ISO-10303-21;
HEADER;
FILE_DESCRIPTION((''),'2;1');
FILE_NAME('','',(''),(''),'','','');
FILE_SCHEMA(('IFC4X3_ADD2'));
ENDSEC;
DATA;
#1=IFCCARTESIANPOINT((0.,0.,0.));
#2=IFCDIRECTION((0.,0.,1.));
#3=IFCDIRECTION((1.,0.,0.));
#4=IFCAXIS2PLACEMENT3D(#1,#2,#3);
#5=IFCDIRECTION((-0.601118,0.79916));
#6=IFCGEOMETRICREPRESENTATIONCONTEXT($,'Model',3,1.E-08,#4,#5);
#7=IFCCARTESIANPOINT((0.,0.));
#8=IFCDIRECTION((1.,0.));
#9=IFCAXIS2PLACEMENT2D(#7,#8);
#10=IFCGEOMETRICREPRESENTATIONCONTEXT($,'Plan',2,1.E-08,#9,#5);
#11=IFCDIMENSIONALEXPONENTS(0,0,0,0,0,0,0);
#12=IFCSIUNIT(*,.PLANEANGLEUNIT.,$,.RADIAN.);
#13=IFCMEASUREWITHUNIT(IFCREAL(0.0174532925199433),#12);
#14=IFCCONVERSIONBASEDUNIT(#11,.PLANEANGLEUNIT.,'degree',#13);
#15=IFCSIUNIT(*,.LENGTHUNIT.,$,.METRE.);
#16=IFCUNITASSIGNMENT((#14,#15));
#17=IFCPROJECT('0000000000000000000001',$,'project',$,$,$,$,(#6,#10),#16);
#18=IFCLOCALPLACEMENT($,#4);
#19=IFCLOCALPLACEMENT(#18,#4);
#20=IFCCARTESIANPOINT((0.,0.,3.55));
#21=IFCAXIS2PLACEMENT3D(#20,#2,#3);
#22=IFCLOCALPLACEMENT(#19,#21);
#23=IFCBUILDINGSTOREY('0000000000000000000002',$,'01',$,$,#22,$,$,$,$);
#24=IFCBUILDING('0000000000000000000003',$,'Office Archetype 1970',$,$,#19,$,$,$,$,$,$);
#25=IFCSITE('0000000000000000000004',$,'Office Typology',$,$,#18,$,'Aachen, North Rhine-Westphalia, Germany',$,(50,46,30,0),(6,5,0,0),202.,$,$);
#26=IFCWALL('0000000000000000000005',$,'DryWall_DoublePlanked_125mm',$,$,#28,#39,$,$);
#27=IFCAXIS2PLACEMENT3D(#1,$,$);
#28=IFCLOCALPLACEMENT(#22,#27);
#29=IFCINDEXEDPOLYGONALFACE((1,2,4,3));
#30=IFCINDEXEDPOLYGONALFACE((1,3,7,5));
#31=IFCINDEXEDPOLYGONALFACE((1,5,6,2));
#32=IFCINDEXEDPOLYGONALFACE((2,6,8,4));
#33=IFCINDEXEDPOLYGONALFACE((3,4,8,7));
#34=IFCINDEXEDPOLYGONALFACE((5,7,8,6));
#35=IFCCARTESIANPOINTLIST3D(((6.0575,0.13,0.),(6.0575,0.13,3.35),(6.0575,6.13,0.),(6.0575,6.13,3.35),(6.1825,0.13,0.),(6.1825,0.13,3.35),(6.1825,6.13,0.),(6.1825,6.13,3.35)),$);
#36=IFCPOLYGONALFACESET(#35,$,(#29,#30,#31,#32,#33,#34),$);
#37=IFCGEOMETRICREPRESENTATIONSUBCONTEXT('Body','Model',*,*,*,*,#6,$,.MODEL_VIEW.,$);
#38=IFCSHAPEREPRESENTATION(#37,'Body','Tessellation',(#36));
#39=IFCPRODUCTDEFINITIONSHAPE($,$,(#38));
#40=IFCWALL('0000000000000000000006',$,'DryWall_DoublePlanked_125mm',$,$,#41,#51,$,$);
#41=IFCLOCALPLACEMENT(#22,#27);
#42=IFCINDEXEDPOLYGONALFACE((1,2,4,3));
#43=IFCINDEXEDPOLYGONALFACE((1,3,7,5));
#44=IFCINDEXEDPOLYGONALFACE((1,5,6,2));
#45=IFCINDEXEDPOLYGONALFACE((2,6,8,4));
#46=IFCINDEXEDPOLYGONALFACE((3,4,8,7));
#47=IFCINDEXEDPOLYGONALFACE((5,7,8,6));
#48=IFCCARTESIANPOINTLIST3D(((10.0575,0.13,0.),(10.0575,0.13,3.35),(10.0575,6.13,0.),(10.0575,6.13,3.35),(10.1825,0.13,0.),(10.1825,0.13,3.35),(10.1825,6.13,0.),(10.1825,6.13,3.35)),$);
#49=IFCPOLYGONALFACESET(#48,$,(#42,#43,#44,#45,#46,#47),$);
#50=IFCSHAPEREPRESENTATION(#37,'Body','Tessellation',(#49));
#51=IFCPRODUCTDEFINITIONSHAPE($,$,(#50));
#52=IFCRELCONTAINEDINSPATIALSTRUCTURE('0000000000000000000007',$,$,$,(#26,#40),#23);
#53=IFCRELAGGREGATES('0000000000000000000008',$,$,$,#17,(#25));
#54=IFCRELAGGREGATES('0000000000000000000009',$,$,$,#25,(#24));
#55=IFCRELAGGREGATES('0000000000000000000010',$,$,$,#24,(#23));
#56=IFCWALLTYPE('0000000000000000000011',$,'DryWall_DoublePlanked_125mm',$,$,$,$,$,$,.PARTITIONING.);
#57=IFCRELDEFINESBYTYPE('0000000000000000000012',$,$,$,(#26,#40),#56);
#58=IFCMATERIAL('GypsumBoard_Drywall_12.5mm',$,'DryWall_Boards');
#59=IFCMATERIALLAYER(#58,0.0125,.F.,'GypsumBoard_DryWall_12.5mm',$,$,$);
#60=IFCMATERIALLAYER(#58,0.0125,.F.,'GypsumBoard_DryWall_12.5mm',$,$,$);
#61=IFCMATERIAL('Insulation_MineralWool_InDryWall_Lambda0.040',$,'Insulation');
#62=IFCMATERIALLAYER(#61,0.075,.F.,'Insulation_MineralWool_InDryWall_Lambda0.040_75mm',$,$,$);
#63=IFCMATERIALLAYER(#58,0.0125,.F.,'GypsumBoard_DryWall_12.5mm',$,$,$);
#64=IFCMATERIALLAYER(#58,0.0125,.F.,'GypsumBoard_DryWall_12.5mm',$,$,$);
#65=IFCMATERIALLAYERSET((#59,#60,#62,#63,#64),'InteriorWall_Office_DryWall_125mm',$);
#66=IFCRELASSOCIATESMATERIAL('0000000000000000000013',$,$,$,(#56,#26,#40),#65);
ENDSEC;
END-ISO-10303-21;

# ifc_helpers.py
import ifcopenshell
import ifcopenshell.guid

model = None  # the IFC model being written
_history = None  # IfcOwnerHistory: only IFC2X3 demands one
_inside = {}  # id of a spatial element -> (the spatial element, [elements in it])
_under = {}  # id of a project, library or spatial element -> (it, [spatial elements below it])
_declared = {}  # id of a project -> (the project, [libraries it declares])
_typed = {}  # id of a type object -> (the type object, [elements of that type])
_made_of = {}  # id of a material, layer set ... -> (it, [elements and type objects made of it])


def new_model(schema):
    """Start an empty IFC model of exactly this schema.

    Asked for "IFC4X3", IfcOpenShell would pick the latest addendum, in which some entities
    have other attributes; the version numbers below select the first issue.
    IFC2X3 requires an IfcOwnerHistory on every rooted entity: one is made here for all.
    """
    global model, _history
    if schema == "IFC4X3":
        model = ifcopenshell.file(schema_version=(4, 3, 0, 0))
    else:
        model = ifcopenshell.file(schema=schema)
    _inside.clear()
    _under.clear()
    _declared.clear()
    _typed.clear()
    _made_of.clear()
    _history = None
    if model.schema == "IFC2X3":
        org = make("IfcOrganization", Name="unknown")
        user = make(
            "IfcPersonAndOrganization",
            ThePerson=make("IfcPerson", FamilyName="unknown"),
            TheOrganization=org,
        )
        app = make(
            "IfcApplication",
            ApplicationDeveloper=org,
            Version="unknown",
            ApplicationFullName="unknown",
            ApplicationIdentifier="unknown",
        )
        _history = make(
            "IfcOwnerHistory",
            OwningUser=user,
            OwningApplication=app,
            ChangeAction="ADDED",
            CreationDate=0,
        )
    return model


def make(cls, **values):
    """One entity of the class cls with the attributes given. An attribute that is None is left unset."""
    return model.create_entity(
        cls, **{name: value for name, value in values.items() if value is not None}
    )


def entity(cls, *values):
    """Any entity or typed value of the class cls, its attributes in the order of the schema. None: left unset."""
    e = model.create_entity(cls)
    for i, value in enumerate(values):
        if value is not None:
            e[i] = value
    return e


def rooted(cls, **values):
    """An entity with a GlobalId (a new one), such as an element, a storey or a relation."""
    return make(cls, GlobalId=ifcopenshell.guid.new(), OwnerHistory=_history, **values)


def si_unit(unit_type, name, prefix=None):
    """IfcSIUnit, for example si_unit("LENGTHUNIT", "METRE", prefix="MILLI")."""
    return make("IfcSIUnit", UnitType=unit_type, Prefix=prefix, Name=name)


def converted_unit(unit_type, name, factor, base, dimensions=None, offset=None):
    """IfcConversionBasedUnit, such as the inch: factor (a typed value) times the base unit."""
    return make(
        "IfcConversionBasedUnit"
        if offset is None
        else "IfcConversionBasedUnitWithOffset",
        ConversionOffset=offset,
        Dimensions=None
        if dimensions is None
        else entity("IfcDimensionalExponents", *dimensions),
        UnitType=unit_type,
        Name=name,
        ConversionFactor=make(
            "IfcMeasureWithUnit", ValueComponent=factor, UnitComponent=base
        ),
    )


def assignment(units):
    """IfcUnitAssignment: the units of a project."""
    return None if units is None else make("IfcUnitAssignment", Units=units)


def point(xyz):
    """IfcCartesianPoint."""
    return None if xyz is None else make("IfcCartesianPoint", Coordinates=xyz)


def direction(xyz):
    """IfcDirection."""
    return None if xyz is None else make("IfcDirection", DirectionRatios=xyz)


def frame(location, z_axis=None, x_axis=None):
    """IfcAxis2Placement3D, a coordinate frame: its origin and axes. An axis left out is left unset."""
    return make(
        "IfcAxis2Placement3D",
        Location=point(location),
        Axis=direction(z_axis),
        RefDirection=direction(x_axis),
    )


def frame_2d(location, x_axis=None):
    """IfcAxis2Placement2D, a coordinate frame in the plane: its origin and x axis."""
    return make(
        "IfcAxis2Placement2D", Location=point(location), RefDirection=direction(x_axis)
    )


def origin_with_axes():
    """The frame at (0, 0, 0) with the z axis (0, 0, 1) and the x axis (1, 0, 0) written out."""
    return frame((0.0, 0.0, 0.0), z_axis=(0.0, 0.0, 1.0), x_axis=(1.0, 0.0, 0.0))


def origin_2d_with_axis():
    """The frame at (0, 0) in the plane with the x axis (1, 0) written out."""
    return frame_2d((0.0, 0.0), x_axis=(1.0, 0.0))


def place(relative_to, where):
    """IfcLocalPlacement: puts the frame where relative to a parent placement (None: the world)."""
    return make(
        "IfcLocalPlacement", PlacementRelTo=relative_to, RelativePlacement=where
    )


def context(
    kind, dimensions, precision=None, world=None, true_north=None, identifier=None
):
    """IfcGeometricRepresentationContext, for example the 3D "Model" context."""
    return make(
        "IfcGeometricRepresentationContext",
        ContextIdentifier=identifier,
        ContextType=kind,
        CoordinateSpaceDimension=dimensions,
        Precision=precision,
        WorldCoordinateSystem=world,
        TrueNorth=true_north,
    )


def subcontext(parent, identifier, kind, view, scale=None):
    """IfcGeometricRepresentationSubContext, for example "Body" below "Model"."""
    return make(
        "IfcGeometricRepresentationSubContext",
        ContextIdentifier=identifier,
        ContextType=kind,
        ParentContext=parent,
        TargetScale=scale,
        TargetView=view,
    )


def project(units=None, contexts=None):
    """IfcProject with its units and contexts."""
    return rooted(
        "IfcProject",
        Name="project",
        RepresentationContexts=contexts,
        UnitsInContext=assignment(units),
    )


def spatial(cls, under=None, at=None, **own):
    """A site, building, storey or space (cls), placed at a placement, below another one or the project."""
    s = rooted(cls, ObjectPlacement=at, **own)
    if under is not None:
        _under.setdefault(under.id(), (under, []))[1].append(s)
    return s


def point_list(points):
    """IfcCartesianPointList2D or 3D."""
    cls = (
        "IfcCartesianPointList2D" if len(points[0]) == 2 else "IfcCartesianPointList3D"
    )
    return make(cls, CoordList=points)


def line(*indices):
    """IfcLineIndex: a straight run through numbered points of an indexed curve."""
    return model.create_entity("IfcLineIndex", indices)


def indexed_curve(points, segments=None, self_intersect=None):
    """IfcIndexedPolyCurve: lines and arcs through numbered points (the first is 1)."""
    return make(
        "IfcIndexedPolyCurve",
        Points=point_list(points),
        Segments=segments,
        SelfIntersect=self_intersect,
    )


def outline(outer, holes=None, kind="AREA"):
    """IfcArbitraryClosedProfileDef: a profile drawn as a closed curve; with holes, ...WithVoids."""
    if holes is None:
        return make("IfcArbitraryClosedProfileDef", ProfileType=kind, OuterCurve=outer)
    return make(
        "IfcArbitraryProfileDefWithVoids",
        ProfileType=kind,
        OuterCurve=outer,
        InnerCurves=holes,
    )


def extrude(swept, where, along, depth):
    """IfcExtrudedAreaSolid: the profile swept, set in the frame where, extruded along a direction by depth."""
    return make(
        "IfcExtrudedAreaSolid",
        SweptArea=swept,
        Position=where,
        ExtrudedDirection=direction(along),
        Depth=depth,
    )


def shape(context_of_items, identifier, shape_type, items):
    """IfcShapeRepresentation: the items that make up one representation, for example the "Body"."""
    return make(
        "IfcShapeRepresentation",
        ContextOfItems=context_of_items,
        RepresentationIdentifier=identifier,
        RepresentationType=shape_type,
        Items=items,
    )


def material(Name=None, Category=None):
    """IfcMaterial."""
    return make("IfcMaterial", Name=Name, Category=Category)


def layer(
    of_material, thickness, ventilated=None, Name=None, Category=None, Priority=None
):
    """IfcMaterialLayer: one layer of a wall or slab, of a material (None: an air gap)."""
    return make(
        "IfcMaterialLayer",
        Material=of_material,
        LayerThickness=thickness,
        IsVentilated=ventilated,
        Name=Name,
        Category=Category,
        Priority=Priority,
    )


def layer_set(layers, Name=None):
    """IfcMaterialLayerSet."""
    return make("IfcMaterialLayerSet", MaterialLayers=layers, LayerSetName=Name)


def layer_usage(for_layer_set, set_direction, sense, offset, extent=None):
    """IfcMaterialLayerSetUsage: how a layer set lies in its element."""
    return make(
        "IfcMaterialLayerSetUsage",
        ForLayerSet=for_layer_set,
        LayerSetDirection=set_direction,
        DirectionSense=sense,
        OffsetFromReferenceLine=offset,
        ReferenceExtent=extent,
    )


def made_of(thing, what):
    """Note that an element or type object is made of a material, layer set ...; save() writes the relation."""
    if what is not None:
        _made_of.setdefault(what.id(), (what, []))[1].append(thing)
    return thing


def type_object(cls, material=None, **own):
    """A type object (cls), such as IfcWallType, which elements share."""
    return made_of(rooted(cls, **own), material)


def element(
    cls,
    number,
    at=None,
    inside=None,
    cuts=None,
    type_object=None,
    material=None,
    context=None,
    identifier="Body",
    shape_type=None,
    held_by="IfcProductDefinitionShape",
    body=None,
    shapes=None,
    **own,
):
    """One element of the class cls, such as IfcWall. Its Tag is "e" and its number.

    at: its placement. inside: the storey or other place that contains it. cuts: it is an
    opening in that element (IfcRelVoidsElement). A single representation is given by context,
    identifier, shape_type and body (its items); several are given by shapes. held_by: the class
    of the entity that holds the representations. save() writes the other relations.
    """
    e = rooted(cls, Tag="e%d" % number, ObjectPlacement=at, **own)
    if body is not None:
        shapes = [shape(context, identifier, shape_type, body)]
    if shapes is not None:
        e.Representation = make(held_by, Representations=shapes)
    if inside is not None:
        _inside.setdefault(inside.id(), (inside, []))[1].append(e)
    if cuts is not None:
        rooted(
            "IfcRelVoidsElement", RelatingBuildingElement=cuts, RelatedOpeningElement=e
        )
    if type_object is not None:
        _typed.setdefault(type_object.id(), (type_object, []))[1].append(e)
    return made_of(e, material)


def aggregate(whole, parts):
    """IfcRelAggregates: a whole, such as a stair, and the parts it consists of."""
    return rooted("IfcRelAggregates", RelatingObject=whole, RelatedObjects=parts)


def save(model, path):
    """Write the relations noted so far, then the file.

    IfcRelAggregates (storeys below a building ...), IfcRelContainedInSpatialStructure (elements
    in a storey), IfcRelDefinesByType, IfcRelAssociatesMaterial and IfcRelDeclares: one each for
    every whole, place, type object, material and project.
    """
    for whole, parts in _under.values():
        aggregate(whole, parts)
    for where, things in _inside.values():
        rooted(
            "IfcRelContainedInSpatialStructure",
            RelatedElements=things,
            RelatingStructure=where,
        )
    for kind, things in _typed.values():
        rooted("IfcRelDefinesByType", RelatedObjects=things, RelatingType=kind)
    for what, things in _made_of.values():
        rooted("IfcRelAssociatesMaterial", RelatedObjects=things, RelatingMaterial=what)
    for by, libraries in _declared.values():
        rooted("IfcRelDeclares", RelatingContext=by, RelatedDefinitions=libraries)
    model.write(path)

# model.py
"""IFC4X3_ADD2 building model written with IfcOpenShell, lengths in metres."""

from ifc_helpers import new_model, entity, si_unit, converted_unit, direction, frame, origin_with_axes, origin_2d_with_axis, place, context, subcontext, project, spatial, line, indexed_curve, outline, extrude, material, layer, layer_set, layer_usage, type_object, element, save


model = new_model("IFC4X3_ADD2")

# Units and contexts
model_context = context("Model", 3, precision=1e-08, world=origin_with_axes(), true_north=direction((-0.601118, 0.79916)))
plan_context = context("Plan", 2, precision=1e-08, world=origin_2d_with_axis(), true_north=direction((-0.601118, 0.79916)))
body_context = subcontext(model_context, "Body", "Model", "MODEL_VIEW")
ifc_project = project(units=[converted_unit("PLANEANGLEUNIT", "degree", entity("IfcReal", 0.0174532925199433), si_unit("PLANEANGLEUNIT", "RADIAN"), dimensions=[0, 0, 0, 0, 0, 0, 0]), si_unit("LENGTHUNIT", "METRE")], contexts=[model_context, plan_context])

# Site, building, storey
site_placement = place(None, origin_with_axes())
site = spatial("IfcSite", under=ifc_project, at=site_placement, Name="Office Typology", LongName="Aachen, North Rhine-Westphalia, Germany", RefLatitude=(50, 46, 30, 0), RefLongitude=(6, 5, 0, 0), RefElevation=202.0)
building_placement = place(site_placement, origin_with_axes())
building = spatial("IfcBuilding", under=site, at=building_placement, Name="Office Archetype 1970")
storey_placement = place(building_placement, frame((0.0, 0.0, 3.55), z_axis=(0.0, 0.0, 1.0), x_axis=(1.0, 0.0, 0.0)))
storey = spatial("IfcBuildingStorey", under=building, at=storey_placement, Name="01")

# Walls
ifc_material_1 = material(Name="GypsumBoard_Drywall_12.5mm", Category="DryWall_Boards")
ifc_layer_1 = layer(ifc_material_1, 0.0125, ventilated=False, Name="GypsumBoard_DryWall_12.5mm")
ifc_layer_2 = layer(ifc_material_1, 0.0125, ventilated=False, Name="GypsumBoard_DryWall_12.5mm")
ifc_material_2 = material(Name="Insulation_MineralWool_InDryWall_Lambda0.040", Category="Insulation")
ifc_layer_3 = layer(ifc_material_2, 0.075, ventilated=False, Name="Insulation_MineralWool_InDryWall_Lambda0.040_75mm")
ifc_layer_4 = layer(ifc_material_1, 0.0125, ventilated=False, Name="GypsumBoard_DryWall_12.5mm")
ifc_layer_5 = layer(ifc_material_1, 0.0125, ventilated=False, Name="GypsumBoard_DryWall_12.5mm")
ifc_layer_set_1 = layer_set([ifc_layer_1, ifc_layer_2, ifc_layer_3, ifc_layer_4, ifc_layer_5], Name="InteriorWall_Office_DryWall_125mm")
wall_type_1 = type_object("IfcWallType", Name="DryWall_DoublePlanked_125mm", PredefinedType="PARTITIONING", material=ifc_layer_set_1)
ifc_layer_usage_1 = layer_usage(ifc_layer_set_1, "AXIS2", "POSITIVE", 0.0)
wall_1_placement = place(storey_placement, frame((6.0575, 6.13, 0.0), z_axis=(0.0, 0.0, 1.0), x_axis=(0.0, -1.0, 0.0)))
element("IfcWall", 1, at=wall_1_placement, inside=storey, type_object=wall_type_1, material=ifc_layer_usage_1, Name="DryWall_DoublePlanked_125mm", context=body_context, shape_type="SweptSolid", body=[
    extrude(outline(indexed_curve([(0.0, 0.0), (0.0, 0.125), (6.0, 0.125), (6.0, 0.0)], segments=[line(1, 2, 3, 4, 1)])), origin_with_axes(), (0.0, 0.0, 1.0), 3.35),
])
ifc_layer_usage_2 = layer_usage(ifc_layer_set_1, "AXIS2", "POSITIVE", 0.0)
wall_2_placement = place(storey_placement, frame((10.0575, 6.13, 0.0), z_axis=(0.0, 0.0, 1.0), x_axis=(0.0, -1.0, 0.0)))
element("IfcWall", 2, at=wall_2_placement, inside=storey, type_object=wall_type_1, material=ifc_layer_usage_2, Name="DryWall_DoublePlanked_125mm", context=body_context, shape_type="SweptSolid", body=[
    extrude(outline(indexed_curve([(0.0, 0.0), (0.0, 0.125), (6.0, 0.125), (6.0, 0.0)], segments=[line(1, 2, 3, 4, 1)])), origin_with_axes(), (0.0, 0.0, 1.0), 3.35),
])

save(model, "model.ifc")
